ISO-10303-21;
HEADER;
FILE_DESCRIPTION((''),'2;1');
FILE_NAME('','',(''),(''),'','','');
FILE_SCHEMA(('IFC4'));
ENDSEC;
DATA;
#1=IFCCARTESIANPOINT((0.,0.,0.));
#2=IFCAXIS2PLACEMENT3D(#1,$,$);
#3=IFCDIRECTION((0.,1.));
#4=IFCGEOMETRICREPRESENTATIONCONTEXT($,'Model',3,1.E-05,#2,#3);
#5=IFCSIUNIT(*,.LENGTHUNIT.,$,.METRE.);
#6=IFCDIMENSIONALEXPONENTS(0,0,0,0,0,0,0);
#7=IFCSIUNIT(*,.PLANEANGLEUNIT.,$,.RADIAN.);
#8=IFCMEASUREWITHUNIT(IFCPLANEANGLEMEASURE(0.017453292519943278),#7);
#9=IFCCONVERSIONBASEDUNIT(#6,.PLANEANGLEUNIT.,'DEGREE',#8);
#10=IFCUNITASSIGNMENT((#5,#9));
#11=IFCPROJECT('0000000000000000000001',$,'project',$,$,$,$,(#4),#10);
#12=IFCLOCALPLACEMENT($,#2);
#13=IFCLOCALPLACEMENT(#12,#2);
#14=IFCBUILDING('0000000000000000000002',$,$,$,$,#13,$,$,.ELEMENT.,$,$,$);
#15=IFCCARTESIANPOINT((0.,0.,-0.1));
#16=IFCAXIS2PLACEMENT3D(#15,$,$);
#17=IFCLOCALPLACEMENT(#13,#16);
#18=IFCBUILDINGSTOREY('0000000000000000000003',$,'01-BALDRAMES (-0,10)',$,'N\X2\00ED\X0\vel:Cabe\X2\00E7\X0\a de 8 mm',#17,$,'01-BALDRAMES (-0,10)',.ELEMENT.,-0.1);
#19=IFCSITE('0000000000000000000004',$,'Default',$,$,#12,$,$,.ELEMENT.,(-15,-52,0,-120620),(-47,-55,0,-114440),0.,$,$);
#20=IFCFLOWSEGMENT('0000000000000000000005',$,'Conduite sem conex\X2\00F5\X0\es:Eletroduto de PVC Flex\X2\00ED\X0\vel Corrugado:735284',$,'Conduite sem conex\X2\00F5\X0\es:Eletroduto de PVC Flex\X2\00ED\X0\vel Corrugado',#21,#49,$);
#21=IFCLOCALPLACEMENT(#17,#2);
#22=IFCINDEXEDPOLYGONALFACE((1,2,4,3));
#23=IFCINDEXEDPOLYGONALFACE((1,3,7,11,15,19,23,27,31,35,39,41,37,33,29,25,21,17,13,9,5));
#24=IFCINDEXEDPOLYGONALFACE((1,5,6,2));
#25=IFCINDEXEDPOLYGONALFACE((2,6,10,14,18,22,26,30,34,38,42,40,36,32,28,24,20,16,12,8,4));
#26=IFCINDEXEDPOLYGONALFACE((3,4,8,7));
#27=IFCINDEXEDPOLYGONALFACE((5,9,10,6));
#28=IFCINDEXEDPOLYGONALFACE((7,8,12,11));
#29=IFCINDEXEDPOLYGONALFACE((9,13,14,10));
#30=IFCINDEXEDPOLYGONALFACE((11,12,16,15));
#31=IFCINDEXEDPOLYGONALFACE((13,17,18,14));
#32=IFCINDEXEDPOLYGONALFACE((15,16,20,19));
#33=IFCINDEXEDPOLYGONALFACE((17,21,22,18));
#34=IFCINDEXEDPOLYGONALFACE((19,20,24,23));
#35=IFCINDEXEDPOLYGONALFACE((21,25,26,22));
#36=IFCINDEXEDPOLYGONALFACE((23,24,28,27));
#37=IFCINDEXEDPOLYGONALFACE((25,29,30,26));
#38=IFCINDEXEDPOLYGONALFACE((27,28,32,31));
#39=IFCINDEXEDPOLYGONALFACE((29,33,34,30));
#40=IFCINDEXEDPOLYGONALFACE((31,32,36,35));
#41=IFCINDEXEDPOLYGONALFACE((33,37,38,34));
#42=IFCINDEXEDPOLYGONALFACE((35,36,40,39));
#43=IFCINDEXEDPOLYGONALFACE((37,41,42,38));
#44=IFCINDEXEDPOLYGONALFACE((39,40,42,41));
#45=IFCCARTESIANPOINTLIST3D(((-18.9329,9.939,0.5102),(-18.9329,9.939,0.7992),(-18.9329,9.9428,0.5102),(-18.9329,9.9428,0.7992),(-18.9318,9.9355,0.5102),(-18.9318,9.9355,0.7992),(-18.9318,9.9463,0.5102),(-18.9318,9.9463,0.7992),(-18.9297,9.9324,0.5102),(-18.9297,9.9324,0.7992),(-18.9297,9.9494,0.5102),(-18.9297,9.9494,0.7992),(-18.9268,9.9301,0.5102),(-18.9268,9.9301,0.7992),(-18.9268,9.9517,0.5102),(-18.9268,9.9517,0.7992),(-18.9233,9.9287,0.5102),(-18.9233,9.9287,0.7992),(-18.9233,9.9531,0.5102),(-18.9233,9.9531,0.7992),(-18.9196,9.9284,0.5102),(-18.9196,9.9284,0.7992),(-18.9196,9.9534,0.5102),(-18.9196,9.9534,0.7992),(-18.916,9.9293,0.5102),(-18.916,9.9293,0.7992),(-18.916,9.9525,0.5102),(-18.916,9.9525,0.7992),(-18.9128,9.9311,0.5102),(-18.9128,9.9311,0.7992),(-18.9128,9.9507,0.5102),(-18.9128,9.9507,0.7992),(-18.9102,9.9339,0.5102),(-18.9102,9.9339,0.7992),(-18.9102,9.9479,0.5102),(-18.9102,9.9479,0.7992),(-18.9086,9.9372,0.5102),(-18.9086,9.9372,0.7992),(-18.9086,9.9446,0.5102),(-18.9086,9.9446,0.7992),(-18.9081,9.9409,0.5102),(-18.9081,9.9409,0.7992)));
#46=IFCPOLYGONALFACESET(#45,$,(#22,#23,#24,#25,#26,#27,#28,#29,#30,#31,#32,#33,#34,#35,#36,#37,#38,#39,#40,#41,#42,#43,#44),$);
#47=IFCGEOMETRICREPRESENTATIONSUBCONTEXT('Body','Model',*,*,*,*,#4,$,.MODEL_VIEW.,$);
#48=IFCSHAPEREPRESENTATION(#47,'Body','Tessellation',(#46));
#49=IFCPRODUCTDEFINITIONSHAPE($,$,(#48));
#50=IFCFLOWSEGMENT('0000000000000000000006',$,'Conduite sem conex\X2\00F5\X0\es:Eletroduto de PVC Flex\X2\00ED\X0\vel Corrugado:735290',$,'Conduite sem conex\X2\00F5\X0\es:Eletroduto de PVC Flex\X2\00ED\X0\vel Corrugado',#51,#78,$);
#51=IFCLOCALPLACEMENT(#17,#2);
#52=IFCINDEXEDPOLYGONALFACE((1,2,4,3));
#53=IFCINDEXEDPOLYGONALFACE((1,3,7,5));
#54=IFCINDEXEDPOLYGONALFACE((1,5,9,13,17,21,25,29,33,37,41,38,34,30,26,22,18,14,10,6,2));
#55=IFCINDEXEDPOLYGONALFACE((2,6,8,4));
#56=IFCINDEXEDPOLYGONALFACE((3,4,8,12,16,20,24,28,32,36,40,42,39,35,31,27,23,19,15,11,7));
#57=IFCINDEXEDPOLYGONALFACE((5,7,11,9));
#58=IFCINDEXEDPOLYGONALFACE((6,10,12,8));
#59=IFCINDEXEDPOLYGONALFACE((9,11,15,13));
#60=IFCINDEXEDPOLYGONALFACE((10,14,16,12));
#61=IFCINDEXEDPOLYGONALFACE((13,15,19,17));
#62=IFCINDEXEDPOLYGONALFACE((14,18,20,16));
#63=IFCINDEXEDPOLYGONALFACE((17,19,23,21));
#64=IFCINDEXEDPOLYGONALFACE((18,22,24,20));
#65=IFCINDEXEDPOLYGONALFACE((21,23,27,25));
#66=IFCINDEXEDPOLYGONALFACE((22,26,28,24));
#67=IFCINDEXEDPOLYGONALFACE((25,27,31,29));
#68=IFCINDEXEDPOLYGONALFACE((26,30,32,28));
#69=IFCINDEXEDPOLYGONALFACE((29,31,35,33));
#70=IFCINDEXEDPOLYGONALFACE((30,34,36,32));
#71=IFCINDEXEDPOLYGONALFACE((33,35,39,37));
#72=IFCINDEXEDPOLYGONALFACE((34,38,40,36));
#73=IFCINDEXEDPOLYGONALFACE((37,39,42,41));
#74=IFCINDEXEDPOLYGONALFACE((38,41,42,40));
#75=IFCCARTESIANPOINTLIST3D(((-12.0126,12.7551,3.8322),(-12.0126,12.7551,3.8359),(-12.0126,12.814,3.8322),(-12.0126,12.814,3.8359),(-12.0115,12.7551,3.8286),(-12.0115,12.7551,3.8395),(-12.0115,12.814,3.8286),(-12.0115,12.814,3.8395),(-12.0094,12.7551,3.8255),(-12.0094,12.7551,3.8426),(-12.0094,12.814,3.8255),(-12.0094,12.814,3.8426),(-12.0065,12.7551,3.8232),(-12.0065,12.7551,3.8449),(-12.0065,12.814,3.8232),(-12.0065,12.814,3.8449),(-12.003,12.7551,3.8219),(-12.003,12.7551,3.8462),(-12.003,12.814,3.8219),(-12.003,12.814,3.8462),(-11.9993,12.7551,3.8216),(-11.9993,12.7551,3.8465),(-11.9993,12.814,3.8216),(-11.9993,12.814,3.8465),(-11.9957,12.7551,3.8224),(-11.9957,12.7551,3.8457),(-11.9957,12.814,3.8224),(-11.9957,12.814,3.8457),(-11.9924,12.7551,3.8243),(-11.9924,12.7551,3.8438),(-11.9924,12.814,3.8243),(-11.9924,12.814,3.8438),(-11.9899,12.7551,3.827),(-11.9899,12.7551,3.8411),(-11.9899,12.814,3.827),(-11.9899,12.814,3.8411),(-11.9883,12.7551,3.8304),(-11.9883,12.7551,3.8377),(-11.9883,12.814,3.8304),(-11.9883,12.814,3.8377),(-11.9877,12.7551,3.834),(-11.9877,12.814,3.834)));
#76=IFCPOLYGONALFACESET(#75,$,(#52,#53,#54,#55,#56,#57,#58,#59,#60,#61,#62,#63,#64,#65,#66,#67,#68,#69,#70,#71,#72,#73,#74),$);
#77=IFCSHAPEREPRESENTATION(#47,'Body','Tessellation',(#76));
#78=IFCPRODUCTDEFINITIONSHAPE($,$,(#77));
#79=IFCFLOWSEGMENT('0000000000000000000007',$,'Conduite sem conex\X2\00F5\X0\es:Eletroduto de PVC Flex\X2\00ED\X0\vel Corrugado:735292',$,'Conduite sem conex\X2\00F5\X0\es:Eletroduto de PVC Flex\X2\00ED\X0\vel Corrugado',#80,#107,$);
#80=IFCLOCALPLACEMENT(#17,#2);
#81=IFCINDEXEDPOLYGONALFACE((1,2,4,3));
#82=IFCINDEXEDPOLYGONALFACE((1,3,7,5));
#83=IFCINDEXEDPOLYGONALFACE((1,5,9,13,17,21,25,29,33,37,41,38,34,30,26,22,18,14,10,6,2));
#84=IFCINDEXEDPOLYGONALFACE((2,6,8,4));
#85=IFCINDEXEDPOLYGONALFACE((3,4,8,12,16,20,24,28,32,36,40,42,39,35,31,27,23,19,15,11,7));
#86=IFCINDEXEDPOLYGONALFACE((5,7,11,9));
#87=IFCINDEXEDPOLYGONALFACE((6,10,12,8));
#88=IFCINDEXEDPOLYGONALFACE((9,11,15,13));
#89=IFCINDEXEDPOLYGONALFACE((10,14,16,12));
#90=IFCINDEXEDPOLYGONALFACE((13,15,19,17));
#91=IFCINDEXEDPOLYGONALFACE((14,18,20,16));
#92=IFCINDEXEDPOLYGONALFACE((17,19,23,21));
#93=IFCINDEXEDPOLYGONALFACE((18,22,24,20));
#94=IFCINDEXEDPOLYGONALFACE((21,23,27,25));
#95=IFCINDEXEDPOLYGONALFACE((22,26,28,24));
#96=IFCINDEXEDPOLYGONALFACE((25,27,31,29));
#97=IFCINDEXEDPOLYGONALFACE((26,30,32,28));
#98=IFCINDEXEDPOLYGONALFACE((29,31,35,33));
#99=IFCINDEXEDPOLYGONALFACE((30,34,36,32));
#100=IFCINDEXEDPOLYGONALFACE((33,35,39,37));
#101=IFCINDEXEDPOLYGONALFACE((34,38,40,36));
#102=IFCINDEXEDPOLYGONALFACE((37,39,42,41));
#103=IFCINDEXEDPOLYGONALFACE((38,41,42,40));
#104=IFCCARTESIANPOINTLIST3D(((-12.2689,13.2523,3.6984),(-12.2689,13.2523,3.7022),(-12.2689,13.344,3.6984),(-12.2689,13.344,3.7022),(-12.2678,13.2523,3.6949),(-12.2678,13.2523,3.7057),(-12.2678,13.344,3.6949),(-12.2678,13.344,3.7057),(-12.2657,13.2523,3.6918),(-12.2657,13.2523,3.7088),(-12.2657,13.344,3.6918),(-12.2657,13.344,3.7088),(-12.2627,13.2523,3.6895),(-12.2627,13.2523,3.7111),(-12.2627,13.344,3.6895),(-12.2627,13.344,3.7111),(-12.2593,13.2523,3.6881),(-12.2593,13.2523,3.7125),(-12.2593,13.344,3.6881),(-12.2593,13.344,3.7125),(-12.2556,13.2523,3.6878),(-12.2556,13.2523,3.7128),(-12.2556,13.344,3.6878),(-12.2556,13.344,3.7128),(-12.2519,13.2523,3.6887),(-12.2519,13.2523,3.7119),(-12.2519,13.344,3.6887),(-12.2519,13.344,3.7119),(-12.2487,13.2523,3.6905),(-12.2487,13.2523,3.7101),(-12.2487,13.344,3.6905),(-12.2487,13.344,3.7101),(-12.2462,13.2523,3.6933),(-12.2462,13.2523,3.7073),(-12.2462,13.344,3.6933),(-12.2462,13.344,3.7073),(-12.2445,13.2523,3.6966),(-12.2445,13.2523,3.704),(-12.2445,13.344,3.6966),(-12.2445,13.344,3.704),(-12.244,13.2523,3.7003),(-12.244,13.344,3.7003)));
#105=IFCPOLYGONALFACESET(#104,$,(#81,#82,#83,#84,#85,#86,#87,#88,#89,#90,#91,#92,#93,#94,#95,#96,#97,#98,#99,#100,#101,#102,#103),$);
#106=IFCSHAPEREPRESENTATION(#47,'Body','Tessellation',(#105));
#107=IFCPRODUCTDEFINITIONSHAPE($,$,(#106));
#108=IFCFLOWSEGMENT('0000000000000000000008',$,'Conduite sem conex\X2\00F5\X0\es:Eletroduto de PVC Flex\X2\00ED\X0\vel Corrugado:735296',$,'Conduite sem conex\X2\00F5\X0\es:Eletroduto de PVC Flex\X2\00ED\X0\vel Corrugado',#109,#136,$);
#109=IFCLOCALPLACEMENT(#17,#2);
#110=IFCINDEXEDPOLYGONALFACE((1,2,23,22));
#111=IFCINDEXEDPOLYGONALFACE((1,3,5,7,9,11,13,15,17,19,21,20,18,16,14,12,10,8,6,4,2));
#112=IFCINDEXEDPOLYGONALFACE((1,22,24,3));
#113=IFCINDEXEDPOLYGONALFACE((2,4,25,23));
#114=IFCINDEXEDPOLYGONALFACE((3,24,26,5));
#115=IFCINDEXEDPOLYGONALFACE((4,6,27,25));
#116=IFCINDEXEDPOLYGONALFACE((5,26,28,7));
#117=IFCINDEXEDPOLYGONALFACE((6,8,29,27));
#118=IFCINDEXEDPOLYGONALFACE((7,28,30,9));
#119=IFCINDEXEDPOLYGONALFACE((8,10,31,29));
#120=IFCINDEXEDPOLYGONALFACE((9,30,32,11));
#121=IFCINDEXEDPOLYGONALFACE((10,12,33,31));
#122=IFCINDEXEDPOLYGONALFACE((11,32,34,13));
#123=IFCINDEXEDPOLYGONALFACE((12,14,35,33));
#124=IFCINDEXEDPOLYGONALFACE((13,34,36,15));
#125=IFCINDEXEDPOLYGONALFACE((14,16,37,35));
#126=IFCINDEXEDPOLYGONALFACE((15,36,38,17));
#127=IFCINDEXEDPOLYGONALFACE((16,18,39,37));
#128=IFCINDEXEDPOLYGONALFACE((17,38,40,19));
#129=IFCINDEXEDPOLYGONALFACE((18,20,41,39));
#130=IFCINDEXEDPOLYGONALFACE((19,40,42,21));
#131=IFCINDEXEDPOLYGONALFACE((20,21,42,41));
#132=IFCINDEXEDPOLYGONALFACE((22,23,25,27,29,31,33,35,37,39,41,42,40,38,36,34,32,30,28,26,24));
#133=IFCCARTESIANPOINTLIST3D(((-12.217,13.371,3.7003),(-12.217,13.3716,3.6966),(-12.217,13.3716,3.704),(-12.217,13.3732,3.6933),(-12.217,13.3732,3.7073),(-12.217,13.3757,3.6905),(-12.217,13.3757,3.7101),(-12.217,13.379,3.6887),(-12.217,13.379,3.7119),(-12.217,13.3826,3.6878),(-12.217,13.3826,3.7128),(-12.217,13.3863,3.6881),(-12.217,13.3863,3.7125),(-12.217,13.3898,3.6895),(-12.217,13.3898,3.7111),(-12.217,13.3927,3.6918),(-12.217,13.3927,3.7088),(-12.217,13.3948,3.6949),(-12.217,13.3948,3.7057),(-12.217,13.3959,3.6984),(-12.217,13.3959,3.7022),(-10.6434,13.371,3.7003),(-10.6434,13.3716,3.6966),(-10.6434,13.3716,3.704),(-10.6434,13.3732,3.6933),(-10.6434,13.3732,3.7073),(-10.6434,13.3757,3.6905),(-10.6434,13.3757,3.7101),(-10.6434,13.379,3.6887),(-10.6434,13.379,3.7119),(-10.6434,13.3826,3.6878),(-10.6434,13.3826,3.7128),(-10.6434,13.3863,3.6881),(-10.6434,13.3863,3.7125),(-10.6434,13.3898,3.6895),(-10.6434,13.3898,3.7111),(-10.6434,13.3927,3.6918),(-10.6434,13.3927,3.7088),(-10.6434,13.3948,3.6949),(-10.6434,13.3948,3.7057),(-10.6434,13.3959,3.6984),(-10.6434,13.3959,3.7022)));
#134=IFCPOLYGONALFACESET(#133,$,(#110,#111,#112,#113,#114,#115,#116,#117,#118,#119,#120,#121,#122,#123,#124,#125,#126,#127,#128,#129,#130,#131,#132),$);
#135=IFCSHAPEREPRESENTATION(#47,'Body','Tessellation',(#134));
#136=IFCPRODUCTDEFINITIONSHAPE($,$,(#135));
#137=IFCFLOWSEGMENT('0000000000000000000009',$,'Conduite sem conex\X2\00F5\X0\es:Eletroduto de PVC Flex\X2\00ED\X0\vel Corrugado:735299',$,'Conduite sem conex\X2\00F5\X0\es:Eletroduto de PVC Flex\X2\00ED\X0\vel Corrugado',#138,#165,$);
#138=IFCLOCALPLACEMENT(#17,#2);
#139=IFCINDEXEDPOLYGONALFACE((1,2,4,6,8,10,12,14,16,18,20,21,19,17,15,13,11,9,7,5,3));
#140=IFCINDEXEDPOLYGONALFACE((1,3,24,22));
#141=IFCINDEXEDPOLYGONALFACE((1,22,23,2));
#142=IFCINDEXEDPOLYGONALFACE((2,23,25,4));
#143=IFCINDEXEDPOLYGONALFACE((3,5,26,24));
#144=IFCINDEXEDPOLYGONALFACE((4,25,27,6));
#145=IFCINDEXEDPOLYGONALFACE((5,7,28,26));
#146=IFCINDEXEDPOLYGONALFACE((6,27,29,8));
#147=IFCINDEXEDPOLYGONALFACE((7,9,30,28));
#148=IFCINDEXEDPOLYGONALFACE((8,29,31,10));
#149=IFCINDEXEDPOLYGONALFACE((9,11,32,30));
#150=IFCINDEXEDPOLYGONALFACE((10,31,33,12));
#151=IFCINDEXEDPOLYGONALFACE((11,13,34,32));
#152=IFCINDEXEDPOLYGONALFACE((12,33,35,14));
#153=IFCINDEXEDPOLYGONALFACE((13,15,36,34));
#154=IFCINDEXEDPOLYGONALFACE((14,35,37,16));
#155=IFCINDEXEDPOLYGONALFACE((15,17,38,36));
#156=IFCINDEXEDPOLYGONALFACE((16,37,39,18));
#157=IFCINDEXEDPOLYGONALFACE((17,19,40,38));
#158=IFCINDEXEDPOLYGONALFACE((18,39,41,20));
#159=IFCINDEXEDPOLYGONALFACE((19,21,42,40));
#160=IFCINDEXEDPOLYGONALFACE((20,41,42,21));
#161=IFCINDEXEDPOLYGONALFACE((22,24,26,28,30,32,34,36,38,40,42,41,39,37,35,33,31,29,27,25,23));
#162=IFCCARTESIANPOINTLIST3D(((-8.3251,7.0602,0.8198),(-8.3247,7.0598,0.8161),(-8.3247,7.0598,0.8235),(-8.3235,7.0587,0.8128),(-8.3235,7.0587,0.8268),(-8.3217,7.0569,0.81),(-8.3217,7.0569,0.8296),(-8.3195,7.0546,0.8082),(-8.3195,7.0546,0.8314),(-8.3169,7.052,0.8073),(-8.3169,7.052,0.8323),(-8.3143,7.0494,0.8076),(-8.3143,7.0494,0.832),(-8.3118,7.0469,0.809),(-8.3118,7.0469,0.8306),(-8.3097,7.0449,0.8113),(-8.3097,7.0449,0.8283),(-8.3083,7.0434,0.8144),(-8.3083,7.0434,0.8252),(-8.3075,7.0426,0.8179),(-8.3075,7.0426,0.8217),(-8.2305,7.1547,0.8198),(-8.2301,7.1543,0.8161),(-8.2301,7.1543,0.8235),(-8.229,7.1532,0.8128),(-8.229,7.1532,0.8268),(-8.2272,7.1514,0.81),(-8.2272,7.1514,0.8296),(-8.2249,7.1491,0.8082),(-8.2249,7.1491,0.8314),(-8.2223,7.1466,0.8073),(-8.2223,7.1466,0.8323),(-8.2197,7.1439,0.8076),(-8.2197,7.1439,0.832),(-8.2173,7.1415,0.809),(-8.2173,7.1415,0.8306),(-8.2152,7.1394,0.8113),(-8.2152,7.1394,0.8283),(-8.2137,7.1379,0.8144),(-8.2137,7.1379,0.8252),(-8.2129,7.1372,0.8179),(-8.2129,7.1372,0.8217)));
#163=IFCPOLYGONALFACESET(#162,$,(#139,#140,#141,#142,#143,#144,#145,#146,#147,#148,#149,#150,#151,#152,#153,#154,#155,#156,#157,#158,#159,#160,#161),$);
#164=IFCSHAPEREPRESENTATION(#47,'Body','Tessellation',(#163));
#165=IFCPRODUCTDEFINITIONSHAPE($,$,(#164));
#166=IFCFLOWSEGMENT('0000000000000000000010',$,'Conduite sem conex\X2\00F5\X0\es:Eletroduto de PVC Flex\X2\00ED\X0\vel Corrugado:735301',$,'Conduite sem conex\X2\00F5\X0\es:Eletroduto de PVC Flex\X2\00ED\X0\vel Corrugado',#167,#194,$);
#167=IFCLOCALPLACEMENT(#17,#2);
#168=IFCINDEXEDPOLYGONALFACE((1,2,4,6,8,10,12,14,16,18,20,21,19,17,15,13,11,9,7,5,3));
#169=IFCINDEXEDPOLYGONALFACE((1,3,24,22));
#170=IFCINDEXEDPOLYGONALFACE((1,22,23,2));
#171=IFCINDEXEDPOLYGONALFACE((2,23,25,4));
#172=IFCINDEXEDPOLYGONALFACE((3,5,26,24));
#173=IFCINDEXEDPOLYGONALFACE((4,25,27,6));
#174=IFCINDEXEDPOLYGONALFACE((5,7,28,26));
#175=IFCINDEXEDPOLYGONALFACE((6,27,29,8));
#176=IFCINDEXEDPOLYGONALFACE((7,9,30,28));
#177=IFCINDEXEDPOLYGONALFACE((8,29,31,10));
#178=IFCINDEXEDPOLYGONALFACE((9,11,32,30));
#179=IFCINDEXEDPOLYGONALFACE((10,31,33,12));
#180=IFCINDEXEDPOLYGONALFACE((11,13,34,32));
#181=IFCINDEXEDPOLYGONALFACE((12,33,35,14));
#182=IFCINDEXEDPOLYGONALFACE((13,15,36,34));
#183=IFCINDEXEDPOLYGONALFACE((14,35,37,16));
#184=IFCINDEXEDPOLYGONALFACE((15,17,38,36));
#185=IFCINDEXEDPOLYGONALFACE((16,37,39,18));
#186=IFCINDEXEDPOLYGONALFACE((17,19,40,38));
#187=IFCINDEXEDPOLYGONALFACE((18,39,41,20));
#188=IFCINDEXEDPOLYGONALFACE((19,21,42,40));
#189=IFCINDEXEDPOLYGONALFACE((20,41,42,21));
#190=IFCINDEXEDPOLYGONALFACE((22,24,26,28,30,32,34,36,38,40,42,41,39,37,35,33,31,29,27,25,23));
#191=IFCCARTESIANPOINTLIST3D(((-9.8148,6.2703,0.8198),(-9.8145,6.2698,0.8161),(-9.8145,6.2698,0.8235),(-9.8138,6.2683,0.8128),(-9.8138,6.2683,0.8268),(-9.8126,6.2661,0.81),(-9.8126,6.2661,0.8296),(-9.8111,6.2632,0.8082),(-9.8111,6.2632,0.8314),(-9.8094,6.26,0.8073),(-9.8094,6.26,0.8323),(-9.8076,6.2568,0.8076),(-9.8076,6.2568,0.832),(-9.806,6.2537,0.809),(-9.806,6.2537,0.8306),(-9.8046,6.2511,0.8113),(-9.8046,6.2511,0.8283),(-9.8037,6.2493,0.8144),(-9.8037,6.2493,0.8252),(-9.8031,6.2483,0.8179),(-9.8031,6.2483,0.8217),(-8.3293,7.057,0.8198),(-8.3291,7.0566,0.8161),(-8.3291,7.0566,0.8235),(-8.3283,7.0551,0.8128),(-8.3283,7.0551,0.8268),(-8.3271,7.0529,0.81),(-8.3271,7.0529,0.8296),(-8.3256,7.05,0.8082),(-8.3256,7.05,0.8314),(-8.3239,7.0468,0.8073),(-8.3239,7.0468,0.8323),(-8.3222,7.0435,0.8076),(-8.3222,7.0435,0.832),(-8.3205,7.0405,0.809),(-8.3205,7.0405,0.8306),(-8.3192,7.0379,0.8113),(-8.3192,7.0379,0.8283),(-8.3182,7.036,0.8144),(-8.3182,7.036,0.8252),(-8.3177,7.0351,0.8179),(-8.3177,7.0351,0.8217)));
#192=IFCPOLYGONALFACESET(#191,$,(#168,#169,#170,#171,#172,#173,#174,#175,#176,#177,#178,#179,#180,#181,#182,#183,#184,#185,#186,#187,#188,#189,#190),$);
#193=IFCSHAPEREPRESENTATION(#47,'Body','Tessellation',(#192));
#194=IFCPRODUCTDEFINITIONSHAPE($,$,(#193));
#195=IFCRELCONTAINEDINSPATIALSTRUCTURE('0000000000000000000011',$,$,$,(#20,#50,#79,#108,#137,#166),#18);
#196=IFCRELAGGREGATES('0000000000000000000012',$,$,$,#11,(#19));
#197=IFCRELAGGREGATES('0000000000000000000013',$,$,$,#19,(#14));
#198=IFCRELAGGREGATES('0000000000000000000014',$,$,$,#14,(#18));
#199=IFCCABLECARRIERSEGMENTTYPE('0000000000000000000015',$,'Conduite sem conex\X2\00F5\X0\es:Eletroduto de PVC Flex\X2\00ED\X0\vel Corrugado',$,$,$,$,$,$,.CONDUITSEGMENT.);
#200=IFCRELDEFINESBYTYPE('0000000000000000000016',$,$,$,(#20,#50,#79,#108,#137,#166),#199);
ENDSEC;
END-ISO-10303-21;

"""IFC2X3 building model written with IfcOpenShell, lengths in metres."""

from ifc_helpers import new_model, entity, si_unit, converted_unit, direction, frame, frame_2d, origin, origin_2d_with_axis, place, context, subcontext, project, spatial, circle, extrude, type_object, element, save


model = new_model("IFC2X3")

# Units and contexts
model_context = context("Model", 3, precision=1e-05, world=origin(), true_north=direction((0.0, 1.0)))
body_context = subcontext(model_context, "Body", "Model", "MODEL_VIEW")
ifc_project = project(units=[si_unit("LENGTHUNIT", "METRE"), converted_unit("PLANEANGLEUNIT", "DEGREE", entity("IfcPlaneAngleMeasure", 0.017453292519943278), si_unit("PLANEANGLEUNIT", "RADIAN"), dimensions=[0, 0, 0, 0, 0, 0, 0])], contexts=[model_context])

# Site, building, storey
site_placement = place(None, origin())
site = spatial("IfcSite", under=ifc_project, at=site_placement, Name="Default", CompositionType="ELEMENT", RefLatitude=(-15, -52, 0, -120620), RefLongitude=(-47, -55, 0, -114440), RefElevation=0.0)
building_placement = place(site_placement, origin())
building = spatial("IfcBuilding", under=site, at=building_placement, CompositionType="ELEMENT")
storey_placement = place(building_placement, frame((0.0, 0.0, -0.1)))
storey = spatial("IfcBuildingStorey", under=building, at=storey_placement, Name="01-BALDRAMES (-0,10)", ObjectType="Nível:Cabeça de 8 mm", LongName="01-BALDRAMES (-0,10)", CompositionType="ELEMENT", Elevation=-0.1)

# Flow segments
cable_carrier_segment_type = type_object("IfcCableCarrierSegmentType", Name="Conduite sem conexões:Eletroduto de PVC Flexível Corrugado", PredefinedType="CONDUITSEGMENT")
flow_segment_1_placement = place(storey_placement, origin())
element("IfcFlowSegment", 1, at=flow_segment_1_placement, inside=storey, type_object=cable_carrier_segment_type, Name="Conduite sem conexões:Eletroduto de PVC Flexível Corrugado:735284", ObjectType="Conduite sem conexões:Eletroduto de PVC Flexível Corrugado", context=body_context, shape_type="SweptSolid", body=[
    extrude(circle(Radius=0.0125, at=frame_2d((0.0, 0.0), x_axis=(1.0, 0.0))), frame((-18.9206, 9.9409, 0.5102)), (0.0, 0.0, 1.0), 0.289),
])
flow_segment_2_placement = place(storey_placement, origin())
element("IfcFlowSegment", 2, at=flow_segment_2_placement, inside=storey, type_object=cable_carrier_segment_type, Name="Conduite sem conexões:Eletroduto de PVC Flexível Corrugado:735290", ObjectType="Conduite sem conexões:Eletroduto de PVC Flexível Corrugado", context=body_context, shape_type="SweptSolid", body=[
    extrude(circle(Radius=0.0125, at=origin_2d_with_axis()), frame((-12.0002, 12.7551, 3.834), z_axis=(0.0, 1.0, 0.0), x_axis=(1.0, 0.0, 0.0)), (0.0, 0.0, 1.0), 0.0589),
])
flow_segment_3_placement = place(storey_placement, origin())
element("IfcFlowSegment", 3, at=flow_segment_3_placement, inside=storey, type_object=cable_carrier_segment_type, Name="Conduite sem conexões:Eletroduto de PVC Flexível Corrugado:735292", ObjectType="Conduite sem conexões:Eletroduto de PVC Flexível Corrugado", context=body_context, shape_type="SweptSolid", body=[
    extrude(circle(Radius=0.0125, at=frame_2d((0.0, 0.0), x_axis=(1.0, 0.0))), frame((-12.2565, 13.2523, 3.7003), z_axis=(0.0, 1.0, 0.0), x_axis=(1.0, 0.0, 0.0)), (0.0, 0.0, 1.0), 0.0917),
])
flow_segment_4_placement = place(storey_placement, origin())
element("IfcFlowSegment", 4, at=flow_segment_4_placement, inside=storey, type_object=cable_carrier_segment_type, Name="Conduite sem conexões:Eletroduto de PVC Flexível Corrugado:735296", ObjectType="Conduite sem conexões:Eletroduto de PVC Flexível Corrugado", context=body_context, shape_type="SweptSolid", body=[
    extrude(circle(Radius=0.0125, at=origin_2d_with_axis()), frame((-12.217, 13.3835, 3.7003), z_axis=(1.0, 0.0, 0.0), x_axis=(0.0, -1.0, 0.0)), (0.0, 0.0, 1.0), 1.5736),
])
flow_segment_5_placement = place(storey_placement, origin())
element("IfcFlowSegment", 5, at=flow_segment_5_placement, inside=storey, type_object=cable_carrier_segment_type, Name="Conduite sem conexões:Eletroduto de PVC Flexível Corrugado:735299", ObjectType="Conduite sem conexões:Eletroduto de PVC Flexível Corrugado", context=body_context, shape_type="SweptSolid", body=[
    extrude(circle(Radius=0.0125, at=frame_2d((0.0, 0.0), x_axis=(1.0, 0.0))), frame((-8.3162, 7.0514, 0.8198), z_axis=(0.707107, 0.707107, 0.0), x_axis=(-0.707107, 0.707107, 0.0)), (0.0, 0.0, 1.0), 0.1337),
])
flow_segment_6_placement = place(storey_placement, origin())
element("IfcFlowSegment", 6, at=flow_segment_6_placement, inside=storey, type_object=cable_carrier_segment_type, Name="Conduite sem conexões:Eletroduto de PVC Flexível Corrugado:735301", ObjectType="Conduite sem conexões:Eletroduto de PVC Flexível Corrugado", context=body_context, shape_type="SweptSolid", body=[
    extrude(circle(Radius=0.0125, at=frame_2d((0.0, 0.0), x_axis=(1.0, 0.0))), frame((-9.8089, 6.2592, 0.8198), z_axis=(0.883696, 0.468061, 0.0), x_axis=(-0.468061, 0.883696, 0.0)), (0.0, 0.0, 1.0), 1.681),
])

save(model, "model.ifc")
